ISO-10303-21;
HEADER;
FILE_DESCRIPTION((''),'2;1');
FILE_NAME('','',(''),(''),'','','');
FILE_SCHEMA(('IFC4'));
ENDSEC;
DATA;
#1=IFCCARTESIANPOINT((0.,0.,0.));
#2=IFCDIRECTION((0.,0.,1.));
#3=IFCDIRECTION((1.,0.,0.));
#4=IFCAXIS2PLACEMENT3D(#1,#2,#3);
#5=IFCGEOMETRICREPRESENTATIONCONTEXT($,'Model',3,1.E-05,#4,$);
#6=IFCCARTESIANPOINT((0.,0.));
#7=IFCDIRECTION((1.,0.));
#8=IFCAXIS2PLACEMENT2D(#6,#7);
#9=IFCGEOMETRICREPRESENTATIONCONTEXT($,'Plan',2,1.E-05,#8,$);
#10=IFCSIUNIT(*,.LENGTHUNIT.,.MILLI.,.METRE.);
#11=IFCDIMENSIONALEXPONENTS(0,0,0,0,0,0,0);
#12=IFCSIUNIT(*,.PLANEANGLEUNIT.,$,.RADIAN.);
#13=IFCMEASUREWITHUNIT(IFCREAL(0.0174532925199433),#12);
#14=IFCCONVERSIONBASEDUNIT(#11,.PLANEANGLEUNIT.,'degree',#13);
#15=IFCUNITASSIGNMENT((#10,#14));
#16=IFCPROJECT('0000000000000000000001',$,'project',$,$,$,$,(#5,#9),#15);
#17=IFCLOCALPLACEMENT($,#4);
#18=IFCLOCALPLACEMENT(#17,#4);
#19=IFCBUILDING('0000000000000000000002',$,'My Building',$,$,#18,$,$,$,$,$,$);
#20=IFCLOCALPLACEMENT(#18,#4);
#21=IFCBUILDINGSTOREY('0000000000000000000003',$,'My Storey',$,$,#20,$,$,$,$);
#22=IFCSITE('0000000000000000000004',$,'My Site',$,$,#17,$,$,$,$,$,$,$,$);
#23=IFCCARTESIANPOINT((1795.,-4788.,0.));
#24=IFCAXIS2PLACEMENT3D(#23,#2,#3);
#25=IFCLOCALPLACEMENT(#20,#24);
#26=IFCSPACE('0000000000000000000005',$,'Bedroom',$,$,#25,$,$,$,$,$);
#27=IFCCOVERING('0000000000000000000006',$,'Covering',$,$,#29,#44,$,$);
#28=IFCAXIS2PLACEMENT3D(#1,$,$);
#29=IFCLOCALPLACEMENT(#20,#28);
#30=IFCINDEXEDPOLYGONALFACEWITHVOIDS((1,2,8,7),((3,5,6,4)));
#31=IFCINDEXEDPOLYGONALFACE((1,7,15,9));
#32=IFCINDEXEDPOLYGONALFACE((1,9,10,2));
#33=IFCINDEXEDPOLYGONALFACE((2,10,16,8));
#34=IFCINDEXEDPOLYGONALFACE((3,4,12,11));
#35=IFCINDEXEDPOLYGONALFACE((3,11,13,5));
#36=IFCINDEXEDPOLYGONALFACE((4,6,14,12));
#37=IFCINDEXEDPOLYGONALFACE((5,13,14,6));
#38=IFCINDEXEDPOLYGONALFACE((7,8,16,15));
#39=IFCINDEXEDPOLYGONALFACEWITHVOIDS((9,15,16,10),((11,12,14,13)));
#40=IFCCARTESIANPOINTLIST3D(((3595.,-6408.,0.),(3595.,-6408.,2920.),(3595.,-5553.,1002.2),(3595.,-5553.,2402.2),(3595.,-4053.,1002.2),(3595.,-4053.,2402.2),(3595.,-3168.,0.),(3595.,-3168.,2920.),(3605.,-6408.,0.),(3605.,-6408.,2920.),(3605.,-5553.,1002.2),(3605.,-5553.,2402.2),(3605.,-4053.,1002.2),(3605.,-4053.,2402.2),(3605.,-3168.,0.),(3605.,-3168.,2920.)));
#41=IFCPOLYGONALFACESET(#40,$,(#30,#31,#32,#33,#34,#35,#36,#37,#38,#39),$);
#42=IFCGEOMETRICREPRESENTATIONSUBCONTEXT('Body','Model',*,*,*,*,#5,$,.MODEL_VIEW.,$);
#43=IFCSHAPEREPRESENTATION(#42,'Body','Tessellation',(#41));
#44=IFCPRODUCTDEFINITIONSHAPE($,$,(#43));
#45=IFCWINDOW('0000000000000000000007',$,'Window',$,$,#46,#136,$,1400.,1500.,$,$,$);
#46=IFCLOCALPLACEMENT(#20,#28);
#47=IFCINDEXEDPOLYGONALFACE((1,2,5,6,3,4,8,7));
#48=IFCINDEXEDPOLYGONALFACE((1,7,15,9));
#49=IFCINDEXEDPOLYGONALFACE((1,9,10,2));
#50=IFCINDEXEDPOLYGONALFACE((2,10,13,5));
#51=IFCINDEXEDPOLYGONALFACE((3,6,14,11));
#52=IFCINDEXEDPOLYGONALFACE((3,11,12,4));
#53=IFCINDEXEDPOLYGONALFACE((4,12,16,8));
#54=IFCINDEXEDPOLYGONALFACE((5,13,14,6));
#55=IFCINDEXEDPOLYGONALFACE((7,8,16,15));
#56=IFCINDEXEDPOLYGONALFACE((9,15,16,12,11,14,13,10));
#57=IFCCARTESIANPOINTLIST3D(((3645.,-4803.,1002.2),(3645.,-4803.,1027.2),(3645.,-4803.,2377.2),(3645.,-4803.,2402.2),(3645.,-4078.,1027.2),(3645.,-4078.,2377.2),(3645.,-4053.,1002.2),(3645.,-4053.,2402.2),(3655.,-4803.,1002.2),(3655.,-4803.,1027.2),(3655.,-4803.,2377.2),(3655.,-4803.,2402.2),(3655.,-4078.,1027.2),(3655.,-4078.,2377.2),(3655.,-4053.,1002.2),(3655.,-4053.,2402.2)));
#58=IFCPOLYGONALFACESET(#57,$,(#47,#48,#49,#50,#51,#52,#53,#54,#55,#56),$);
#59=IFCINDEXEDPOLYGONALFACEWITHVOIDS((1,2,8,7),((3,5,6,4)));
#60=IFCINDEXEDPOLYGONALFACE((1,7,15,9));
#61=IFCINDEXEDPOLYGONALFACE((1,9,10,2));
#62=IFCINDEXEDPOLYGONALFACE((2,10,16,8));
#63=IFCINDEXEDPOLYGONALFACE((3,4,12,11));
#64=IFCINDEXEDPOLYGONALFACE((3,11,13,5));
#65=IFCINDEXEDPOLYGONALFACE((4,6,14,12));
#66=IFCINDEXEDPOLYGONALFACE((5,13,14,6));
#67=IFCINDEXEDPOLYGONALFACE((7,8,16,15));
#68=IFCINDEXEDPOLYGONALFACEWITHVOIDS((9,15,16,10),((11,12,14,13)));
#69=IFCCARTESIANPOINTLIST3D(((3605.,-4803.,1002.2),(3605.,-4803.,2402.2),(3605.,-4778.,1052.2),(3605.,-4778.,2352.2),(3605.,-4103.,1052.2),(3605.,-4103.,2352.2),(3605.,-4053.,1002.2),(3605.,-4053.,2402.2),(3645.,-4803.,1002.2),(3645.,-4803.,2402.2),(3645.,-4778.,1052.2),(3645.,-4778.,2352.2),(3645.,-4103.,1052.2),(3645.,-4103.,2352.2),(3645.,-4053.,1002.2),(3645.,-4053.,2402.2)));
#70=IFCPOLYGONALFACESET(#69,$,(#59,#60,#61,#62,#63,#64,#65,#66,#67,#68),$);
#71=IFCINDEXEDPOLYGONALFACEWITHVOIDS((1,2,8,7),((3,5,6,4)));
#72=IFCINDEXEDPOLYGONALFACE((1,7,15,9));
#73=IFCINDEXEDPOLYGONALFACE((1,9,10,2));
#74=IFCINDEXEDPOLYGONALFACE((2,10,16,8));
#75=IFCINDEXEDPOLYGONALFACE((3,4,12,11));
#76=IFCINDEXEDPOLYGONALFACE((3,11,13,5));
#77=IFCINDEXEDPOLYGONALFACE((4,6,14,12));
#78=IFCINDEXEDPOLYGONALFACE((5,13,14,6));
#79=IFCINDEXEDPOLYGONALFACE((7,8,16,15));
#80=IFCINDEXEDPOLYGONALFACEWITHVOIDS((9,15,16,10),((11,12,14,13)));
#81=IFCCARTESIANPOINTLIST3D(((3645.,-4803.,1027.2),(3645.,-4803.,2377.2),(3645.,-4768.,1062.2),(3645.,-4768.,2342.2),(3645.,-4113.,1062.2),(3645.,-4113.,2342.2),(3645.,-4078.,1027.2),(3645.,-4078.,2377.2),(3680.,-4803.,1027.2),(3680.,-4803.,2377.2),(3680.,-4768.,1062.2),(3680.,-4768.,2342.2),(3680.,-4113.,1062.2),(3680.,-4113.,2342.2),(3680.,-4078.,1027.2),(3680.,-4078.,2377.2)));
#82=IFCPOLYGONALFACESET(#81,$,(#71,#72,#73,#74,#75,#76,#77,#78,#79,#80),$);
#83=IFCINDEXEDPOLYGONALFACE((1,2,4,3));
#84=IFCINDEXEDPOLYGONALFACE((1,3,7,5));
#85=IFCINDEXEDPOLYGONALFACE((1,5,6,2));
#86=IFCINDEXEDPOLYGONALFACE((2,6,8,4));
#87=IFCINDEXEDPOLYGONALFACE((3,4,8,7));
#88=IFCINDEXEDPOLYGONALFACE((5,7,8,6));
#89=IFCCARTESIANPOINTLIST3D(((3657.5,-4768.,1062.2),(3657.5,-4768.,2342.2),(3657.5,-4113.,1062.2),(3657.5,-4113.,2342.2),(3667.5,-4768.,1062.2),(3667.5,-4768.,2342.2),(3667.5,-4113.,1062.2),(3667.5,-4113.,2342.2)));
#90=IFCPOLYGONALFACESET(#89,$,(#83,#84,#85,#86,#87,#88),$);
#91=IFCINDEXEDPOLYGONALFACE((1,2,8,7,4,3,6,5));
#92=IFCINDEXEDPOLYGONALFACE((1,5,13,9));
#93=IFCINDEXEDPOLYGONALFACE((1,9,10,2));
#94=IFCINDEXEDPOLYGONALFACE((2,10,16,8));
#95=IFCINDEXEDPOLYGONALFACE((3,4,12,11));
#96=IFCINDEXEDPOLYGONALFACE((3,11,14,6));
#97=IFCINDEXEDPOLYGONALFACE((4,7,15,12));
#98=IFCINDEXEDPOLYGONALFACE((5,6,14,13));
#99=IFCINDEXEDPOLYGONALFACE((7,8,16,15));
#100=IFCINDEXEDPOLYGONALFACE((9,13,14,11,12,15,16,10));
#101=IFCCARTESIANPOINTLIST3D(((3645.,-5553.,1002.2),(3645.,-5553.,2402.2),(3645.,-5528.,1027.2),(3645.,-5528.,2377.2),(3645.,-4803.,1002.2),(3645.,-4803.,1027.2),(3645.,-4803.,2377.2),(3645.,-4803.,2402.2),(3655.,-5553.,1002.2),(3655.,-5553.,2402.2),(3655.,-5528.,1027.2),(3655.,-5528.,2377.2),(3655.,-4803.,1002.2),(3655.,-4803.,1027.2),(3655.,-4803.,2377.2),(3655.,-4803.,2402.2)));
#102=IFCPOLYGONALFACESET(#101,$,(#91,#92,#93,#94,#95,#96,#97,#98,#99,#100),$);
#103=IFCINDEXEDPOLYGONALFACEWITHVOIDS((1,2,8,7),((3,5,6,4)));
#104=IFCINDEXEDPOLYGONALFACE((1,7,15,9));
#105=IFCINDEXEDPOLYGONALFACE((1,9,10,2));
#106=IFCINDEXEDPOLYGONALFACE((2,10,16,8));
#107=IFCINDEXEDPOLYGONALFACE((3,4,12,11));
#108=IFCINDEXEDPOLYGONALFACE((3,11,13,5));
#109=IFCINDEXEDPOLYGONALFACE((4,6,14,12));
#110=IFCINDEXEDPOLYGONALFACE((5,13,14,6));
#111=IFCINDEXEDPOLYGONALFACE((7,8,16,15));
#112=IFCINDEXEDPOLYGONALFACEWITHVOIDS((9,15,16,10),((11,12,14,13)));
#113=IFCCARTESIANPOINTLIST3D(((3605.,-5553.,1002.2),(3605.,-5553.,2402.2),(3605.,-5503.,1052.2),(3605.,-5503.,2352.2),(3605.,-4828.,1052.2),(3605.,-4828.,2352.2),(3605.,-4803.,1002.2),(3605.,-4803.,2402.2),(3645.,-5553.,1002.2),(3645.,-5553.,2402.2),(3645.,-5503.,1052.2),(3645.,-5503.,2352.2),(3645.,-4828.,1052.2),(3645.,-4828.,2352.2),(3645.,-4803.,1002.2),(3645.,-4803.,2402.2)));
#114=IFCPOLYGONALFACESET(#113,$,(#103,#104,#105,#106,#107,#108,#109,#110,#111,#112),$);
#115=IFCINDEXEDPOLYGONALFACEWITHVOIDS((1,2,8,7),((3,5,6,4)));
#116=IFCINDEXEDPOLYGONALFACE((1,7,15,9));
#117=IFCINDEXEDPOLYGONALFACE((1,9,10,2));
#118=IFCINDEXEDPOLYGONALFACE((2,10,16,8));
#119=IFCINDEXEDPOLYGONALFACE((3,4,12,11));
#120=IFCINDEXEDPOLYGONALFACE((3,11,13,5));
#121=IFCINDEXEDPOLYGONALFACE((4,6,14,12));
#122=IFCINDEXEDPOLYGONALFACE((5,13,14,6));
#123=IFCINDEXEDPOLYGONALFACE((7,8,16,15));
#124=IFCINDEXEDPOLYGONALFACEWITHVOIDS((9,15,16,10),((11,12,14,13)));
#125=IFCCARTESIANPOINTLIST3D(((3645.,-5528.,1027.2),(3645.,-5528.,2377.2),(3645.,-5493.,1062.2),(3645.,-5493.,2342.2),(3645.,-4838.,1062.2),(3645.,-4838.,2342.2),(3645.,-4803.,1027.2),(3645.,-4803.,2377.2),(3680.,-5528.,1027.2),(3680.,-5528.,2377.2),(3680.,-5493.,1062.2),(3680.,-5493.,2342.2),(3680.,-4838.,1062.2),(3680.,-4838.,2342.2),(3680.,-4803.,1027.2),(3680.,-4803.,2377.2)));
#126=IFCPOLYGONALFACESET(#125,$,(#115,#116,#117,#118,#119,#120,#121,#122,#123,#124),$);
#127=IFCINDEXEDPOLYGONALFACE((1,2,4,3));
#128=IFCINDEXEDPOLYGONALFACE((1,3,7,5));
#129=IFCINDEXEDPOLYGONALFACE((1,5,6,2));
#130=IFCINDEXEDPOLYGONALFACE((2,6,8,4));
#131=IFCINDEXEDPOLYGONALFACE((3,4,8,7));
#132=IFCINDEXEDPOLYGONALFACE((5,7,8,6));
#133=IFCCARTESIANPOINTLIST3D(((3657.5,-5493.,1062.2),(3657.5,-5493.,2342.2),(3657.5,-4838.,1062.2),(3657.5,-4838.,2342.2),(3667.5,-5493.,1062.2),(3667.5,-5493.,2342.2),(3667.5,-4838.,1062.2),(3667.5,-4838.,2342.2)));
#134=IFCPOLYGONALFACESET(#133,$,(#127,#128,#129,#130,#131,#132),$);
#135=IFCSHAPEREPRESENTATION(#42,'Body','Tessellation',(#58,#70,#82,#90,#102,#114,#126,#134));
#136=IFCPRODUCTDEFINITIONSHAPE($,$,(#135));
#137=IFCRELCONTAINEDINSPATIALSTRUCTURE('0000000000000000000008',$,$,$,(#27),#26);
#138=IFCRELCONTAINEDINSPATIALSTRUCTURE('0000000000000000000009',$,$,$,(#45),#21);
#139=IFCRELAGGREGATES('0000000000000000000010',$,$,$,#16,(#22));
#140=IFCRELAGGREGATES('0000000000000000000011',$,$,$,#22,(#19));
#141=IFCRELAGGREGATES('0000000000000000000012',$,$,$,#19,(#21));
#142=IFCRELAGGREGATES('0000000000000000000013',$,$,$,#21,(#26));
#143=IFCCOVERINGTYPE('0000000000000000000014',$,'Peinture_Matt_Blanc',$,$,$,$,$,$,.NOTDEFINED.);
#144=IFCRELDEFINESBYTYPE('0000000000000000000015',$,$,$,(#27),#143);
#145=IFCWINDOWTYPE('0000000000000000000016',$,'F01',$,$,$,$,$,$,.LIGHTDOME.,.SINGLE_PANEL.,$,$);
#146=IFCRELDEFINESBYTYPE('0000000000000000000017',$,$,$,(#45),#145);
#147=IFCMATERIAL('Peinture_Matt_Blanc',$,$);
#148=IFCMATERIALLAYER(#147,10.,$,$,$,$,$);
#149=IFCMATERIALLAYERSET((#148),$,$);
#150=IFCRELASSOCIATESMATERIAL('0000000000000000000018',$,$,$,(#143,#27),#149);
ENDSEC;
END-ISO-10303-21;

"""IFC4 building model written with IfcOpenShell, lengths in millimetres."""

from ifc_helpers import new_model, entity, si_unit, converted_unit, frame, origin_with_axes, origin_2d_with_axis, place, context, subcontext, project, spatial, line, indexed_curve, outline, extrude, clip, halfspace, shape, source, transform, mapped, material, layer, layer_set, layer_usage, type_object, type_shapes, element, fill, save


model = new_model("IFC4")

# Units and contexts
model_context = context("Model", 3, precision=1e-05, world=origin_with_axes())
plan_context = context("Plan", 2, precision=1e-05, world=origin_2d_with_axis())
body_context_1 = subcontext(model_context, "Body", "Model", "MODEL_VIEW")
body_context_2 = subcontext(plan_context, "Body", "Plan", "PLAN_VIEW")
ifc_project = project(units=[si_unit("LENGTHUNIT", "METRE", prefix="MILLI"), converted_unit("PLANEANGLEUNIT", "degree", entity("IfcReal", 0.0174532925199433), si_unit("PLANEANGLEUNIT", "RADIAN"), dimensions=[0, 0, 0, 0, 0, 0, 0])], contexts=[model_context, plan_context])

# Site, building, storey
site_placement = place(None, origin_with_axes())
site = spatial("IfcSite", under=ifc_project, at=site_placement, Name="My Site")
building_placement = place(site_placement, origin_with_axes())
building = spatial("IfcBuilding", under=site, at=building_placement, Name="My Building")
storey_placement = place(building_placement, origin_with_axes())
storey = spatial("IfcBuildingStorey", under=building, at=storey_placement, Name="My Storey")

# Shared definitions
space_placement = place(storey_placement, frame((1795.0, -4788.0, 0.0), z_axis=(0.0, 0.0, 1.0), x_axis=(1.0, 0.0, 0.0)))
space = spatial("IfcSpace", under=storey, at=space_placement, Name="Bedroom")

# Covering, openings, window
ifc_material_1 = material(Name="Peinture_Matt_Blanc")
ifc_layer_1 = layer(ifc_material_1, 10.0)
ifc_layer_set_1 = layer_set([ifc_layer_1])
ifc_layer_usage_1 = layer_usage(ifc_layer_set_1, "AXIS2", "POSITIVE", 0.0)
covering_type_1 = type_object("IfcCoveringType", Name="Peinture_Matt_Blanc", PredefinedType="NOTDEFINED", material=ifc_layer_set_1)
covering_1_placement = place(space_placement, frame((1810.0, -1620.0, 0.0), z_axis=(0.0, 0.0, 1.0), x_axis=(0.000002, 1.0, 0.0)))
covering_1 = element("IfcCovering", 1, at=covering_1_placement, inside=space, type_object=covering_type_1, material=ifc_layer_usage_1, Name="Covering", context=body_context_1, shape_type="Clipping", body=[
    clip(clip(extrude(outline(indexed_curve([(0.0, 0.0), (0.0, 10.0), (3240.0, 10.0), (3240.0, 0.0), (0.0, 0.0)], self_intersect=False)), origin_with_axes(), (0.0, 0.0, 1.0), 2920.0), halfspace(frame((0.0, 0.0, 2920.0), z_axis=(0.0, 0.0, 1.0), x_axis=(-1.0, 0.0, 0.0)), False)), halfspace(frame((0.0, 0.0, 2920.0), z_axis=(0.0, 0.0, 1.0), x_axis=(-1.0, 0.0, 0.0)), False)),
])
shared_shape_1 = source(origin_with_axes(), body_context_1, "Body", "SweptSolid", [
    extrude(outline(indexed_curve([(0.0, 0.0), (1500.0, 0.0), (1500.0, 1400.0), (0.0, 1400.0)], segments=[line(1, 2, 3, 4, 1)])), frame((0.0, -600.0, 0.0), z_axis=(0.0, -1.0, 0.0), x_axis=(1.0, 0.0, 0.0)), (0.0, 0.0, -1.0), 1200.0),
])
opening_1_placement = place(covering_1_placement, frame((2355.0, 50.0, 1002.2), z_axis=(0.0, 0.0, 1.0), x_axis=(-1.0, -0.000001, 0.0)))
opening_1 = element("IfcOpeningElement", 2, at=opening_1_placement, cuts=covering_1, PredefinedType="OPENING", context=body_context_1, shape_type="MappedRepresentation", body=[
    mapped(shared_shape_1, transform((0.0, 0.0, 0.0), x_axis=(1.0, 0.0, 0.0), y_axis=(0.0, 1.0, 0.0), z_axis=(0.0, 0.0, 1.0), scale=1.0)),
])
shared_shape_2 = source(origin_with_axes(), body_context_1, "Body", "SweptSolid", [
    extrude(outline(indexed_curve([(0.0, 0.0), (1500.0, 0.0), (1500.0, 1400.0), (0.0, 1400.0)], segments=[line(3, 2), line(2, 1), line(1, 4), line(4, 3)], self_intersect=False)), frame((0.0, -100.0, 0.0), z_axis=(0.0, -1.0, 0.0), x_axis=(1.0, 0.0, 0.0)), (0.0, 0.0, -1.0), 400.0),
])
opening_2_placement = place(covering_1_placement, frame((855.0, -200.0, 1002.2), z_axis=(0.0, 0.0, 1.0), x_axis=(1.0, 0.0, 0.0)))
element("IfcOpeningElement", 3, at=opening_2_placement, cuts=covering_1, PredefinedType="OPENING", context=body_context_1, shape_type="MappedRepresentation", body=[
    mapped(shared_shape_2, transform((0.0, 0.0, 0.0), x_axis=(1.0, 0.0, 0.0), y_axis=(0.0, 1.0, 0.0), z_axis=(0.0, 0.0, 1.0), scale=1.0)),
])
window_type = type_object("IfcWindowType", Name="F01", PartitioningType="SINGLE_PANEL", PredefinedType="LIGHTDOME")
shared_shape_3 = source(origin_with_axes(), body_context_1, "Body", "SolidModel", [
    extrude(outline(indexed_curve([(750.0, 0.0), (0.0, 0.0), (0.0, 1400.0), (750.0, 1400.0), (750.0, 1375.0), (25.0, 1375.0), (25.0, 25.0), (750.0, 25.0)], segments=[line(1, 2, 3, 4, 5, 6, 7, 8, 1)])), frame((0.0, 90.0, 0.0), z_axis=(0.0, -1.0, 0.0), x_axis=(1.0, 0.0, 0.0)), (0.0, 0.0, -1.0), 10.0),
    extrude(outline(indexed_curve([(0.0, 0.0), (750.0, 0.0), (750.0, 1400.0), (0.0, 1400.0)], segments=[line(1, 2, 3, 4, 1)]), holes=[indexed_curve([(50.0, 50.0), (725.0, 50.0), (725.0, 1350.0), (50.0, 1350.0)], segments=[line(1, 2, 3, 4, 1)])]), frame((0.0, 50.0, 0.0), z_axis=(0.0, -1.0, 0.0), x_axis=(1.0, 0.0, 0.0)), (0.0, 0.0, -1.0), 40.0),
    extrude(outline(indexed_curve([(0.0, 0.0), (725.0, 0.0), (725.0, 1350.0), (0.0, 1350.0)], segments=[line(1, 2, 3, 4, 1)]), holes=[indexed_curve([(35.0, 35.0), (690.0, 35.0), (690.0, 1315.0), (35.0, 1315.0)], segments=[line(1, 2, 3, 4, 1)])]), frame((25.0, 90.0, 25.0), z_axis=(0.0, -1.0, 0.0), x_axis=(1.0, 0.0, 0.0)), (0.0, 0.0, -1.0), 35.0),
    extrude(outline(indexed_curve([(35.0, 35.0), (690.0, 35.0), (690.0, 1315.0), (35.0, 1315.0), (35.0, 35.0)])), frame((25.0, 102.5, 25.0), z_axis=(0.0, -1.0, 0.0), x_axis=(1.0, 0.0, 0.0)), (0.0, 0.0, -1.0), 10.0),
    extrude(outline(indexed_curve([(0.0, 1400.0), (750.0, 1400.0), (750.0, 0.0), (0.0, 0.0), (0.0, 25.0), (725.0, 25.0), (725.0, 1375.0), (0.0, 1375.0)], segments=[line(1, 2, 3, 4, 5, 6, 7, 8, 1)])), frame((750.0, 90.0, 0.0), z_axis=(0.0, -1.0, 0.0), x_axis=(1.0, 0.0, 0.0)), (0.0, 0.0, -1.0), 10.0),
    extrude(outline(indexed_curve([(0.0, 0.0), (750.0, 0.0), (750.0, 1400.0), (0.0, 1400.0)], segments=[line(1, 2, 3, 4, 1)]), holes=[indexed_curve([(25.0, 50.0), (700.0, 50.0), (700.0, 1350.0), (25.0, 1350.0)], segments=[line(1, 2, 3, 4, 1)])]), frame((750.0, 50.0, 0.0), z_axis=(0.0, -1.0, 0.0), x_axis=(1.0, 0.0, 0.0)), (0.0, 0.0, -1.0), 40.0),
    extrude(outline(indexed_curve([(0.0, 0.0), (725.0, 0.0), (725.0, 1350.0), (0.0, 1350.0)], segments=[line(1, 2, 3, 4, 1)]), holes=[indexed_curve([(35.0, 35.0), (690.0, 35.0), (690.0, 1315.0), (35.0, 1315.0)], segments=[line(1, 2, 3, 4, 1)])]), frame((750.0, 90.0, 25.0), z_axis=(0.0, -1.0, 0.0), x_axis=(1.0, 0.0, 0.0)), (0.0, 0.0, -1.0), 35.0),
    extrude(outline(indexed_curve([(35.0, 1315.0), (690.0, 1315.0), (690.0, 35.0), (35.0, 35.0), (35.0, 1315.0)])), frame((750.0, 102.5, 25.0), z_axis=(0.0, -1.0, 0.0), x_axis=(1.0, 0.0, 0.0)), (0.0, 0.0, -1.0), 10.0),
])
shared_shape_4 = source(origin_with_axes(), body_context_2, "Body", "Curve2D", [
    entity("IfcIndexedPolyCurve", entity("IfcCartesianPointList2D", [[50.0, 50.0], [725.0, 50.0]])),
    entity("IfcIndexedPolyCurve", entity("IfcCartesianPointList2D", [[0.0, 100.0], [25.0, 100.0], [25.0, 90.0], [50.0, 90.0], [50.0, 50.0], [0.0, 50.0]]), [entity("IfcLineIndex", [1, 2, 3, 4, 5, 6, 1])]),
    entity("IfcIndexedPolyCurve", entity("IfcCartesianPointList2D", [[750.0, 100.0], [750.0, 100.0], [750.0, 90.0], [725.0, 90.0], [725.0, 50.0], [750.0, 50.0]])),
    entity("IfcIndexedPolyCurve", entity("IfcCartesianPointList2D", [[25.0, 90.0], [60.0, 90.0], [60.0, 125.0], [25.0, 125.0]]), [entity("IfcLineIndex", [1, 2, 3, 4, 1])]),
    entity("IfcIndexedPolyCurve", entity("IfcCartesianPointList2D", [[750.0, 90.0], [715.0, 90.0], [715.0, 125.0], [750.0, 125.0]]), [entity("IfcLineIndex", [1, 2, 3, 4, 1])]),
    entity("IfcIndexedPolyCurve", entity("IfcCartesianPointList2D", [[60.0, 90.0], [715.0, 90.0]])),
    entity("IfcIndexedPolyCurve", entity("IfcCartesianPointList2D", [[60.0, 125.0], [715.0, 125.0]])),
    entity("IfcIndexedPolyCurve", entity("IfcCartesianPointList2D", [[60.0, 107.5], [715.0, 107.5]])),
    entity("IfcIndexedPolyCurve", entity("IfcCartesianPointList2D", [[775.0, 50.0], [1450.0, 50.0]])),
    entity("IfcIndexedPolyCurve", entity("IfcCartesianPointList2D", [[750.0, 100.0], [750.0, 100.0], [750.0, 90.0], [775.0, 90.0], [775.0, 50.0], [750.0, 50.0]])),
    entity("IfcIndexedPolyCurve", entity("IfcCartesianPointList2D", [[1500.0, 100.0], [1475.0, 100.0], [1475.0, 90.0], [1450.0, 90.0], [1450.0, 50.0], [1500.0, 50.0]]), [entity("IfcLineIndex", [1, 2, 3, 4, 5, 6, 1])]),
    entity("IfcIndexedPolyCurve", entity("IfcCartesianPointList2D", [[750.0, 90.0], [785.0, 90.0], [785.0, 125.0], [750.0, 125.0]]), [entity("IfcLineIndex", [1, 2, 3, 4, 1])]),
    entity("IfcIndexedPolyCurve", entity("IfcCartesianPointList2D", [[1475.0, 90.0], [1440.0, 90.0], [1440.0, 125.0], [1475.0, 125.0]]), [entity("IfcLineIndex", [1, 2, 3, 4, 1])]),
    entity("IfcIndexedPolyCurve", entity("IfcCartesianPointList2D", [[785.0, 90.0], [1440.0, 90.0]])),
    entity("IfcIndexedPolyCurve", entity("IfcCartesianPointList2D", [[785.0, 125.0], [1440.0, 125.0]])),
    entity("IfcIndexedPolyCurve", entity("IfcCartesianPointList2D", [[785.0, 107.5], [1440.0, 107.5]])),
])
type_shapes(window_type, [shared_shape_3, shared_shape_4])
window_placement = place(opening_1_placement, frame((0.0, 0.0, 0.0), z_axis=(0.0, 0.0, 1.0), x_axis=(1.0, 0.0, 0.0)))
window = element("IfcWindow", 4, at=window_placement, inside=storey, type_object=window_type, Name="Window", OverallHeight=1400.0, OverallWidth=1500.0, shapes=[
    shape(body_context_1, "Body", "MappedRepresentation", [mapped(shared_shape_3, transform((0.0, 0.0, 0.0), x_axis=(1.0, 0.0, 0.0), y_axis=(0.0, 1.0, 0.0), z_axis=(0.0, 0.0, 1.0), scale=1.0))]),
    shape(body_context_2, "Body", "MappedRepresentation", [mapped(shared_shape_4, transform((0.0, 0.0, 0.0), x_axis=(1.0, 0.0, 0.0), y_axis=(0.0, 1.0, 0.0), z_axis=(0.0, 0.0, 1.0), scale=1.0))]),
])
fill(opening_1, window)

save(model, "model.ifc")
